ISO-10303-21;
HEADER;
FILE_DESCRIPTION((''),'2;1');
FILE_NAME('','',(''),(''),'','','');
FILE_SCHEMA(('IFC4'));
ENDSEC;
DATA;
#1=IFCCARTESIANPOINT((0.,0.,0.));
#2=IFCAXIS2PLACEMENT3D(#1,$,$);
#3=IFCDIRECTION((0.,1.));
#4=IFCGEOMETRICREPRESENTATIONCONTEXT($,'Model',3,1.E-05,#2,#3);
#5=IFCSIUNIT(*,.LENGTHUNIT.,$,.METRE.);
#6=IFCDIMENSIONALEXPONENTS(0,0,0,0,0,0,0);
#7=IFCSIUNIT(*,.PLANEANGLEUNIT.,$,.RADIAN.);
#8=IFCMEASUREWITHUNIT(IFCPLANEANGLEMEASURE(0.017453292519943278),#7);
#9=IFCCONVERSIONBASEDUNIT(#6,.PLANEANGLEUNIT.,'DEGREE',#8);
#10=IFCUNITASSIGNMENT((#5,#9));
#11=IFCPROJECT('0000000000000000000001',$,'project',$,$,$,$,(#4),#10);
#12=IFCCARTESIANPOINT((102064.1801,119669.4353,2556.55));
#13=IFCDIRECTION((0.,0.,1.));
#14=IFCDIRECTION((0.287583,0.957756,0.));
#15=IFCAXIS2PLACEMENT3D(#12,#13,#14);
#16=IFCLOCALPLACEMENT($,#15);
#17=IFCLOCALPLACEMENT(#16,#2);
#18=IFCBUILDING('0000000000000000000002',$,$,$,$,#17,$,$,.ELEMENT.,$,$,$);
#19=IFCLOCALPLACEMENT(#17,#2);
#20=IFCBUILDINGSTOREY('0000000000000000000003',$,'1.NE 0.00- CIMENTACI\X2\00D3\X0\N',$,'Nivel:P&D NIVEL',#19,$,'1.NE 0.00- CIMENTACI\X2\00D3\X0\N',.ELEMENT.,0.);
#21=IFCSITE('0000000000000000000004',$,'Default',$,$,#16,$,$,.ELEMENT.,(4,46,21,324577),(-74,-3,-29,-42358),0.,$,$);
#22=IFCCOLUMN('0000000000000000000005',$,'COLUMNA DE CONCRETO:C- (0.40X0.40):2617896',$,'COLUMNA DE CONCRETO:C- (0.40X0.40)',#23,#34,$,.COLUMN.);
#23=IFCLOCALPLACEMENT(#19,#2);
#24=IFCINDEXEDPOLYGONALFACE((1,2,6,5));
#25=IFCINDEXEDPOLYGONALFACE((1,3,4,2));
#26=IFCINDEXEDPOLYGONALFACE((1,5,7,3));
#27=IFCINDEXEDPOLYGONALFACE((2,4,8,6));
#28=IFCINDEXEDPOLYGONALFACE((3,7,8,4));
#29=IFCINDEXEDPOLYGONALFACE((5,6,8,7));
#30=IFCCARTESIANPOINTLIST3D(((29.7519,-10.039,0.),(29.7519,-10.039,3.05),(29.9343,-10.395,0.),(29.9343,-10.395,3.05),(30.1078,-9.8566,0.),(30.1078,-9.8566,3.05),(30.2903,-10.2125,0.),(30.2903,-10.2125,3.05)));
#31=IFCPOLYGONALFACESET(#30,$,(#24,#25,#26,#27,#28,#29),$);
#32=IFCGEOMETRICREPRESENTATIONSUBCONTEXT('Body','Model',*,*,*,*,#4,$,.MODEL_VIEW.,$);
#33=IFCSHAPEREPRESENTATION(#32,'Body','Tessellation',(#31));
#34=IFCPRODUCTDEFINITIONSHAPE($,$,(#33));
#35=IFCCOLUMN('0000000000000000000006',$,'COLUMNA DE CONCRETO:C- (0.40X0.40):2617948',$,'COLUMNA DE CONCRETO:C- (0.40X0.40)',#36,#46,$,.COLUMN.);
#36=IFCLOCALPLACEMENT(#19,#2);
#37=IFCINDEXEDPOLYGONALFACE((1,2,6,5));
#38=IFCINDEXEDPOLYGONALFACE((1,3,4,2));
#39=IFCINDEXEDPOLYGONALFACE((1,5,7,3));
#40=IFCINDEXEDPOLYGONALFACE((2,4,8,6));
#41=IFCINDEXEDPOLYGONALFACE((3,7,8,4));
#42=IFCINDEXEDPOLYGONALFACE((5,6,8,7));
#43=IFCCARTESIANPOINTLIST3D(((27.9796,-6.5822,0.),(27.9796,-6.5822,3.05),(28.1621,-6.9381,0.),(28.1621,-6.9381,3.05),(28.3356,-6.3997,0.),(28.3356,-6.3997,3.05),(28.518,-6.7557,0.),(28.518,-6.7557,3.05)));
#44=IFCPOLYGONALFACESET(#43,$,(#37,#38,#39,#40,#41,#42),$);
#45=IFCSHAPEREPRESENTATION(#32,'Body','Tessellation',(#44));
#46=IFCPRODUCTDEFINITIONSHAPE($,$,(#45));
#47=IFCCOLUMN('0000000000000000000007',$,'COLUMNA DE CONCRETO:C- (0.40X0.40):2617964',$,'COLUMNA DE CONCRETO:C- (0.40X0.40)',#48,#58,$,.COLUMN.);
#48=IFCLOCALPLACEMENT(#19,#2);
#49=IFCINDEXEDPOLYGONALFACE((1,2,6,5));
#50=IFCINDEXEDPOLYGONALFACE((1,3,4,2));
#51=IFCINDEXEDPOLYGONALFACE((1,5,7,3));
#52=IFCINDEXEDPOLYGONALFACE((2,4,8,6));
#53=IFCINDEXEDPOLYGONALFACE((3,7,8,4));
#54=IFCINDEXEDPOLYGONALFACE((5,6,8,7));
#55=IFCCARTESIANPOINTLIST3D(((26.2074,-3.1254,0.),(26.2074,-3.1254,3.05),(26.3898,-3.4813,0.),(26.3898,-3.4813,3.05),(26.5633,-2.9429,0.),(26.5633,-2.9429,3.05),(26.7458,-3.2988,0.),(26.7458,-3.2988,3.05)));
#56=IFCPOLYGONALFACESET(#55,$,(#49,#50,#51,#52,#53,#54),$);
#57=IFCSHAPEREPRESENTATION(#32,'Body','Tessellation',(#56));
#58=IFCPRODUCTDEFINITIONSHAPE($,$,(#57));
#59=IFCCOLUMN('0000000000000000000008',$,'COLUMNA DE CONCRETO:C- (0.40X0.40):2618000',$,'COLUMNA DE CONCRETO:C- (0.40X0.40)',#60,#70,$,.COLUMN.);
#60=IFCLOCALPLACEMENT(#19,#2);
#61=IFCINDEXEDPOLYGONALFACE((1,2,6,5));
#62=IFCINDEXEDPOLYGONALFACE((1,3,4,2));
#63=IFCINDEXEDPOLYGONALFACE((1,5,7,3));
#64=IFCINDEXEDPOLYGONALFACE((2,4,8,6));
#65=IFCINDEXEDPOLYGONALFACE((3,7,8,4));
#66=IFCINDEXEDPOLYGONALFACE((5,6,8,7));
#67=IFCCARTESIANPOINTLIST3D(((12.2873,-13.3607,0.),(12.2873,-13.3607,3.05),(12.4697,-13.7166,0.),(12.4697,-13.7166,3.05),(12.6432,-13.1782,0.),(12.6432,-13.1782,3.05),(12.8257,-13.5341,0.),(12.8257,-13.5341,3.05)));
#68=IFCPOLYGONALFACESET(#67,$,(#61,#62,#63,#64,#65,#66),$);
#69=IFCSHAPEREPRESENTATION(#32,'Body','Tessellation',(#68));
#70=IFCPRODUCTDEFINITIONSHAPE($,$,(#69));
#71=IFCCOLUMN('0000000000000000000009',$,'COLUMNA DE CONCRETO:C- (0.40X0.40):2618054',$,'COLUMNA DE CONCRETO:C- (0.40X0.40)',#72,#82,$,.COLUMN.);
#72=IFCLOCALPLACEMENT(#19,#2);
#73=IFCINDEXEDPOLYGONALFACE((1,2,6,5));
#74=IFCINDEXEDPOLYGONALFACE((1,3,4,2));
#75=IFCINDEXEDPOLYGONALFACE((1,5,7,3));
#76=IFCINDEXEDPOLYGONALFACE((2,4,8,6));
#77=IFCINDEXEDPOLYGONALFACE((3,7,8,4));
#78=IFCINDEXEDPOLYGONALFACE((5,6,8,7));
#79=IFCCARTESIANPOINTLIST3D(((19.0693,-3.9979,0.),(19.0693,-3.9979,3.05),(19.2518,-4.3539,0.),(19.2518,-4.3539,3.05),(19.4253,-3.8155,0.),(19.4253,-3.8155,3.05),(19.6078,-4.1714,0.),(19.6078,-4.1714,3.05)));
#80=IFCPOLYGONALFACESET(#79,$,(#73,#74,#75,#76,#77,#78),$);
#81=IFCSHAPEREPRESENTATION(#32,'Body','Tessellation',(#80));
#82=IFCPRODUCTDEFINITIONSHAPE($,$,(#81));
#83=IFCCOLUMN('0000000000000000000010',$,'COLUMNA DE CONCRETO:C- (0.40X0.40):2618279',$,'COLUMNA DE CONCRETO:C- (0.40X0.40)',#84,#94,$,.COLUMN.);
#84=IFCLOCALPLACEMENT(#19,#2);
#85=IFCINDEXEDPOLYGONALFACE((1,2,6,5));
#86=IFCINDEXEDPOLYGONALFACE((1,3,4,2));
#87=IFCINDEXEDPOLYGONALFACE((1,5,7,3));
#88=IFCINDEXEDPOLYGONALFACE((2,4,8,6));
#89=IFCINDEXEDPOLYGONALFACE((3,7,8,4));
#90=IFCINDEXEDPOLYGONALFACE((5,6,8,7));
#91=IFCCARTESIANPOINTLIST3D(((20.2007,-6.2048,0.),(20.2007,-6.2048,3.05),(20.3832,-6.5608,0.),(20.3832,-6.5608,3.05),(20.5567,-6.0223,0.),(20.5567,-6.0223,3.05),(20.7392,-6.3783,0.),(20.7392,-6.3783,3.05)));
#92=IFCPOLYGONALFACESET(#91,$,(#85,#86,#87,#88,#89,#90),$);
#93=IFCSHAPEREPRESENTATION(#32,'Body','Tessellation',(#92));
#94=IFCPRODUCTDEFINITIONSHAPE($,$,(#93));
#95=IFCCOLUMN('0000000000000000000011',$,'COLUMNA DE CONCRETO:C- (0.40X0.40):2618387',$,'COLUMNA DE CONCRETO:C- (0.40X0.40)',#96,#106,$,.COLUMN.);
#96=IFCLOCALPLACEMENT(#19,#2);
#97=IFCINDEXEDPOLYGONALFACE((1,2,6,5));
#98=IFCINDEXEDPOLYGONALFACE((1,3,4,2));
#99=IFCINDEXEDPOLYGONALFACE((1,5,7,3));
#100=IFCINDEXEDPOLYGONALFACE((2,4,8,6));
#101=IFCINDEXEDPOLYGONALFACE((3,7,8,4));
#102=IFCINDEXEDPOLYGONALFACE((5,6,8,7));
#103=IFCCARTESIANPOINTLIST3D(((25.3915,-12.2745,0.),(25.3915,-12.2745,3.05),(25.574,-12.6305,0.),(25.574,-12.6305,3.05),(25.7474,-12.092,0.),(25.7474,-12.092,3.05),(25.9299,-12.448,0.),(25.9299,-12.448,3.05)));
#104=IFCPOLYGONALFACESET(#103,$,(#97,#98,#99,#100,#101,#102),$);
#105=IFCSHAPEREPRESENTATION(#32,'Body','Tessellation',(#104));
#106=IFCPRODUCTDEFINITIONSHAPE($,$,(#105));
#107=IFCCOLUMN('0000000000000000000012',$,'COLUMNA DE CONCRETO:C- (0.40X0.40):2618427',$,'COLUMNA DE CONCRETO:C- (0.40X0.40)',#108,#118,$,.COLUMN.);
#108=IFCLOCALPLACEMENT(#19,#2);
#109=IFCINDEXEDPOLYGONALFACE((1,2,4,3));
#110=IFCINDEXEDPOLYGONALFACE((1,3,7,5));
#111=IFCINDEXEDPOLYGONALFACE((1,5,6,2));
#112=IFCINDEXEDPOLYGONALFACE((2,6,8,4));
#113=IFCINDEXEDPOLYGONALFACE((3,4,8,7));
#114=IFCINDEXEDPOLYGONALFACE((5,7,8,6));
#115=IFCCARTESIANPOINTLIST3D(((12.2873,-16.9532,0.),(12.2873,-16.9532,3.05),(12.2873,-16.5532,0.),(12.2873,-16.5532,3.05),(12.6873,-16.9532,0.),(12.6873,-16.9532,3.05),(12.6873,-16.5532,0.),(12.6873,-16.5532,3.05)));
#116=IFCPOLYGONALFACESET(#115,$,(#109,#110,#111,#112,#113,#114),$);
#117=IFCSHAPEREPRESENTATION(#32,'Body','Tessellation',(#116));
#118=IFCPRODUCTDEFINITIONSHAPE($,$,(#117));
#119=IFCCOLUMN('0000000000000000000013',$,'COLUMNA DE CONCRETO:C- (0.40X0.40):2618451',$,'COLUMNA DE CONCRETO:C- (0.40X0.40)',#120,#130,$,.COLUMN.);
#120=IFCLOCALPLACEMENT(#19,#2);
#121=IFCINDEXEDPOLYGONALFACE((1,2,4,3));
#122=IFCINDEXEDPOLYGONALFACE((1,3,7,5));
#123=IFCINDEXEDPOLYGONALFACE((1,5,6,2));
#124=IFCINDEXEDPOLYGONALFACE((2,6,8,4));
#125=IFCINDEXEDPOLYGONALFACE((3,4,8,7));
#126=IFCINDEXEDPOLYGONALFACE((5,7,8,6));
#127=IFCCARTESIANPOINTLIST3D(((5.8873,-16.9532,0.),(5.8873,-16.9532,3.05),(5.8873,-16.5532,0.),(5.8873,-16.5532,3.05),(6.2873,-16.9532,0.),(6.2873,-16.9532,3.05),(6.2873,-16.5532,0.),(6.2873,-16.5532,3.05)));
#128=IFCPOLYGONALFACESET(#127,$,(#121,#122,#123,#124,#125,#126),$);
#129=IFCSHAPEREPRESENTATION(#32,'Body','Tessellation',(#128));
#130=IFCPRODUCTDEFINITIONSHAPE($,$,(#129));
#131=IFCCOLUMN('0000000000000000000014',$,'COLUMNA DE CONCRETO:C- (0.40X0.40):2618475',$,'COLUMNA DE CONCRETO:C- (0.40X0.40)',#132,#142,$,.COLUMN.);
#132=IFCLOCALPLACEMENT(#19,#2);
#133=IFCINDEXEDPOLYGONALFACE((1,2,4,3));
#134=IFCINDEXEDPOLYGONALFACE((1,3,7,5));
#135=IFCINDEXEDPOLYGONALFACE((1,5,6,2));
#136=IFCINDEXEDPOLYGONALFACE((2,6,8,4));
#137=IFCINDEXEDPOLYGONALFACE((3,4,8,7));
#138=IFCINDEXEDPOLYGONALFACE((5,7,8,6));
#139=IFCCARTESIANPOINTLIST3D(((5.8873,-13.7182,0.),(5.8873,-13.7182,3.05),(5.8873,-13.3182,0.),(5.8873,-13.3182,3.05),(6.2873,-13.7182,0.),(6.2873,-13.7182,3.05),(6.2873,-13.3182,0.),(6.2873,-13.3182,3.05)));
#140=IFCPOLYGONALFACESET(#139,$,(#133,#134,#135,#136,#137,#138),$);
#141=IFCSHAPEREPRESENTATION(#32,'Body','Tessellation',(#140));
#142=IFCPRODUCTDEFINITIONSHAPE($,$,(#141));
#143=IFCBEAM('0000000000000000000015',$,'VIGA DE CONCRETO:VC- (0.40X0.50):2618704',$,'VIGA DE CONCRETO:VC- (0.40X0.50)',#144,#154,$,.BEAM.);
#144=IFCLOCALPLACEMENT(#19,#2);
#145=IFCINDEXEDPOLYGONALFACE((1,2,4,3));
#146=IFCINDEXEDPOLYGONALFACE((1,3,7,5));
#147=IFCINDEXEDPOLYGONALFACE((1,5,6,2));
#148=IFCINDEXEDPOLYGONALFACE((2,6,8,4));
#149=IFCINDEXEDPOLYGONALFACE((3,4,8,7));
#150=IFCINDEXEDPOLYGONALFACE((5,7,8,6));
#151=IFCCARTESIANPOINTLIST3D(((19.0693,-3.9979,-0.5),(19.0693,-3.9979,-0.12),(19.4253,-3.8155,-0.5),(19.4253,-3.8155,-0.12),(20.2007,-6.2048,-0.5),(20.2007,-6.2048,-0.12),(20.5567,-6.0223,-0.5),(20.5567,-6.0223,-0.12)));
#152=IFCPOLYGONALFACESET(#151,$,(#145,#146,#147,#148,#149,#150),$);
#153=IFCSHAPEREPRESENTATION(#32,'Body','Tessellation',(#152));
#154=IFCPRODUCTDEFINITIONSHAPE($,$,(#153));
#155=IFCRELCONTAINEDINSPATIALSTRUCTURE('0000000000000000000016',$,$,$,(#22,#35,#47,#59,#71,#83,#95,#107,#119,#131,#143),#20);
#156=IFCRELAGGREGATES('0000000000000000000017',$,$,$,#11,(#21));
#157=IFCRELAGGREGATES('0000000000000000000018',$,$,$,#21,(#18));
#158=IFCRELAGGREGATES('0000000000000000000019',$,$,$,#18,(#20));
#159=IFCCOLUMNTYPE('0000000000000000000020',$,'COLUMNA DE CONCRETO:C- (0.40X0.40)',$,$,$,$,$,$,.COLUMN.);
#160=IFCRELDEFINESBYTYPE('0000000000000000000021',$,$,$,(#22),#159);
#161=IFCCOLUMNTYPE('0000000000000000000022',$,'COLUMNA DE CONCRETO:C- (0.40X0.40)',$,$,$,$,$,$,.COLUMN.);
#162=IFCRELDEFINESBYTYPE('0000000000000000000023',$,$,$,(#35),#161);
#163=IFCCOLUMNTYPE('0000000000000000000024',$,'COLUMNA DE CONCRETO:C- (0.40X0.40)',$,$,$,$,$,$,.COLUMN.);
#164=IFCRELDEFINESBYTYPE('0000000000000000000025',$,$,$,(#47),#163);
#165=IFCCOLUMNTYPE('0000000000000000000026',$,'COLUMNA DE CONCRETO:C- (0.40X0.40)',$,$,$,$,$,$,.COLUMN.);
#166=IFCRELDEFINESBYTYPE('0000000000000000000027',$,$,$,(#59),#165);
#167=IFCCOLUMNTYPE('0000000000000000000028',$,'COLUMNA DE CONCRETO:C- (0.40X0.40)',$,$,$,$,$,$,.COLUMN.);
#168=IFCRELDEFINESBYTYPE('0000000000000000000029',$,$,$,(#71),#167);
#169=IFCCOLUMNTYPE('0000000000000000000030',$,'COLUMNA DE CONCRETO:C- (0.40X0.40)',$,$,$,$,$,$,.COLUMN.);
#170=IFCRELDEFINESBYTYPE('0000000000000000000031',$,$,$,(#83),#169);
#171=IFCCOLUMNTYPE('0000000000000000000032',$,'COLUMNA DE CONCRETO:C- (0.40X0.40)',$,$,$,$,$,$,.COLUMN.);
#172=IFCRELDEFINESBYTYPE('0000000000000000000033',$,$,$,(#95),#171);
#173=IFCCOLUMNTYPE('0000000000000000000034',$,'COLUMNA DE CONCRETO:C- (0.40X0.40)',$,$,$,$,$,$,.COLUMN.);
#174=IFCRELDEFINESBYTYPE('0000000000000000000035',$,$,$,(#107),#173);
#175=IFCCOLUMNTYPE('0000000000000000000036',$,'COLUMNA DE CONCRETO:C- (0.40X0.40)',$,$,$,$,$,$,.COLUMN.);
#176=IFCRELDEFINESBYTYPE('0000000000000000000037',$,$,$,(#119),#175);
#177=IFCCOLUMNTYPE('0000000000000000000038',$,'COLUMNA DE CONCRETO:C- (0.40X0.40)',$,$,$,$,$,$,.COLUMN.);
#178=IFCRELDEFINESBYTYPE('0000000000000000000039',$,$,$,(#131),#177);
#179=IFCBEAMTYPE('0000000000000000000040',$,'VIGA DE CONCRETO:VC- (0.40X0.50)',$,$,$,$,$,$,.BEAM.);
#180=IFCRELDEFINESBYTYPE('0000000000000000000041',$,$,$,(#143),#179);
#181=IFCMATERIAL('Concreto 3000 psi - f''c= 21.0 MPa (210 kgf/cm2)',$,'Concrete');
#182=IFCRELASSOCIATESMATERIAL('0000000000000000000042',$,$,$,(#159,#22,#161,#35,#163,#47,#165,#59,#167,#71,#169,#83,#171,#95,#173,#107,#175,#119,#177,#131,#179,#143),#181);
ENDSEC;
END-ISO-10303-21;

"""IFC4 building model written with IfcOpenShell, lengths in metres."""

from ifc_helpers import new_model, entity, si_unit, converted_unit, direction, frame, origin, place, context, subcontext, project, spatial, indexed_curve, outline, extrude, source, transform, mapped, material, type_object, type_shapes, element, save


model = new_model("IFC4")

# Units and contexts
model_context = context("Model", 3, precision=1e-05, world=origin(), true_north=direction((0.0, 1.0)))
body_context = subcontext(model_context, "Body", "Model", "MODEL_VIEW")
ifc_project = project(units=[si_unit("LENGTHUNIT", "METRE"), converted_unit("PLANEANGLEUNIT", "DEGREE", entity("IfcPlaneAngleMeasure", 0.017453292519943278), si_unit("PLANEANGLEUNIT", "RADIAN"), dimensions=[0, 0, 0, 0, 0, 0, 0])], contexts=[model_context])

# Site, building, storey
site_placement = place(None, frame((102064.1801, 119669.4353, 2556.55), z_axis=(0.0, 0.0, 1.0), x_axis=(0.287583, 0.957756, 0.0)))
site = spatial("IfcSite", under=ifc_project, at=site_placement, Name="Default", CompositionType="ELEMENT", RefLatitude=(4, 46, 21, 324577), RefLongitude=(-74, -3, -29, -42358), RefElevation=0.0)
building_placement = place(site_placement, origin())
building = spatial("IfcBuilding", under=site, at=building_placement, CompositionType="ELEMENT")
storey_placement = place(building_placement, origin())
storey = spatial("IfcBuildingStorey", under=building, at=storey_placement, Name="1.NE 0.00- CIMENTACIÓN", ObjectType="Nivel:P&D NIVEL", LongName="1.NE 0.00- CIMENTACIÓN", CompositionType="ELEMENT", Elevation=0.0)

# Columns
ifc_material = material(Name="Concreto 3000 psi - f'c= 21.0 MPa (210 kgf/cm2)", Category="Concrete")
column_type_1 = type_object("IfcColumnType", Name="COLUMNA DE CONCRETO:C- (0.40X0.40)", PredefinedType="COLUMN", material=ifc_material)
shared_shape_1 = source(origin(), body_context, "Body", "SweptSolid", [
    extrude(outline(indexed_curve([(-0.2, -0.2), (0.2, -0.2), (0.2, 0.2), (-0.2, 0.2), (-0.2, -0.2)], self_intersect=False)), frame((30.0211, -10.1258, 0.0), z_axis=(0.0, 0.0, 1.0), x_axis=(-0.889869, -0.456217, 0.0)), (0.0, 0.0, 1.0), 3.05),
])
type_shapes(column_type_1, [shared_shape_1])
column_1_placement = place(storey_placement, origin())
element("IfcColumn", 1, at=column_1_placement, inside=storey, type_object=column_type_1, material=ifc_material, Name="COLUMNA DE CONCRETO:C- (0.40X0.40):2617896", ObjectType="COLUMNA DE CONCRETO:C- (0.40X0.40)", PredefinedType="COLUMN", context=body_context, shape_type="MappedRepresentation", body=[
    mapped(shared_shape_1, transform((0.0, 0.0, 0.0), scale=1.0)),
])
column_type_2 = type_object("IfcColumnType", Name="COLUMNA DE CONCRETO:C- (0.40X0.40)", PredefinedType="COLUMN", material=ifc_material)
shared_shape_2 = source(origin(), body_context, "Body", "SweptSolid", [
    extrude(outline(indexed_curve([(-0.2, -0.2), (0.2, -0.2), (0.2, 0.2), (-0.2, 0.2), (-0.2, -0.2)], self_intersect=False)), frame((28.2488, -6.6689, 0.0), z_axis=(0.0, 0.0, 1.0), x_axis=(-0.889869, -0.456217, 0.0)), (0.0, 0.0, 1.0), 3.05),
])
type_shapes(column_type_2, [shared_shape_2])
column_2_placement = place(storey_placement, origin())
element("IfcColumn", 2, at=column_2_placement, inside=storey, type_object=column_type_2, material=ifc_material, Name="COLUMNA DE CONCRETO:C- (0.40X0.40):2617948", ObjectType="COLUMNA DE CONCRETO:C- (0.40X0.40)", PredefinedType="COLUMN", context=body_context, shape_type="MappedRepresentation", body=[
    mapped(shared_shape_2, transform((0.0, 0.0, 0.0), scale=1.0)),
])
column_type_3 = type_object("IfcColumnType", Name="COLUMNA DE CONCRETO:C- (0.40X0.40)", PredefinedType="COLUMN", material=ifc_material)
shared_shape_3 = source(origin(), body_context, "Body", "SweptSolid", [
    extrude(outline(indexed_curve([(-0.2, -0.2), (0.2, -0.2), (0.2, 0.2), (-0.2, 0.2), (-0.2, -0.2)], self_intersect=False)), frame((26.4766, -3.2121, 0.0), z_axis=(0.0, 0.0, 1.0), x_axis=(-0.889869, -0.456217, 0.0)), (0.0, 0.0, 1.0), 3.05),
])
type_shapes(column_type_3, [shared_shape_3])
column_3_placement = place(storey_placement, origin())
element("IfcColumn", 3, at=column_3_placement, inside=storey, type_object=column_type_3, material=ifc_material, Name="COLUMNA DE CONCRETO:C- (0.40X0.40):2617964", ObjectType="COLUMNA DE CONCRETO:C- (0.40X0.40)", PredefinedType="COLUMN", context=body_context, shape_type="MappedRepresentation", body=[
    mapped(shared_shape_3, transform((0.0, 0.0, 0.0), scale=1.0)),
])
column_type_4 = type_object("IfcColumnType", Name="COLUMNA DE CONCRETO:C- (0.40X0.40)", PredefinedType="COLUMN", material=ifc_material)
shared_shape_4 = source(origin(), body_context, "Body", "SweptSolid", [
    extrude(outline(indexed_curve([(-0.2, -0.2), (0.2, -0.2), (0.2, 0.2), (-0.2, 0.2), (-0.2, -0.2)], self_intersect=False)), frame((12.5565, -13.4474, 0.0), z_axis=(0.0, 0.0, 1.0), x_axis=(-0.889869, -0.456217, 0.0)), (0.0, 0.0, 1.0), 3.05),
])
type_shapes(column_type_4, [shared_shape_4])
column_4_placement = place(storey_placement, origin())
element("IfcColumn", 4, at=column_4_placement, inside=storey, type_object=column_type_4, material=ifc_material, Name="COLUMNA DE CONCRETO:C- (0.40X0.40):2618000", ObjectType="COLUMNA DE CONCRETO:C- (0.40X0.40)", PredefinedType="COLUMN", context=body_context, shape_type="MappedRepresentation", body=[
    mapped(shared_shape_4, transform((0.0, 0.0, 0.0), scale=1.0)),
])
column_type_5 = type_object("IfcColumnType", Name="COLUMNA DE CONCRETO:C- (0.40X0.40)", PredefinedType="COLUMN", material=ifc_material)
shared_shape_5 = source(origin(), body_context, "Body", "SweptSolid", [
    extrude(outline(indexed_curve([(-0.2, -0.2), (0.2, -0.2), (0.2, 0.2), (-0.2, 0.2), (-0.2, -0.2)], self_intersect=False)), frame((19.3385, -4.0847, 0.0), z_axis=(0.0, 0.0, 1.0), x_axis=(-0.889869, -0.456217, 0.0)), (0.0, 0.0, 1.0), 3.05),
])
type_shapes(column_type_5, [shared_shape_5])
column_5_placement = place(storey_placement, origin())
element("IfcColumn", 5, at=column_5_placement, inside=storey, type_object=column_type_5, material=ifc_material, Name="COLUMNA DE CONCRETO:C- (0.40X0.40):2618054", ObjectType="COLUMNA DE CONCRETO:C- (0.40X0.40)", PredefinedType="COLUMN", context=body_context, shape_type="MappedRepresentation", body=[
    mapped(shared_shape_5, transform((0.0, 0.0, 0.0), scale=1.0)),
])
column_type_6 = type_object("IfcColumnType", Name="COLUMNA DE CONCRETO:C- (0.40X0.40)", PredefinedType="COLUMN", material=ifc_material)
shared_shape_6 = source(origin(), body_context, "Body", "SweptSolid", [
    extrude(outline(indexed_curve([(-0.2, -0.2), (0.2, -0.2), (0.2, 0.2), (-0.2, 0.2), (-0.2, -0.2)], self_intersect=False)), frame((20.47, -6.2915, 0.0), z_axis=(0.0, 0.0, 1.0), x_axis=(-0.889869, -0.456217, 0.0)), (0.0, 0.0, 1.0), 3.05),
])
type_shapes(column_type_6, [shared_shape_6])
column_6_placement = place(storey_placement, origin())
element("IfcColumn", 6, at=column_6_placement, inside=storey, type_object=column_type_6, material=ifc_material, Name="COLUMNA DE CONCRETO:C- (0.40X0.40):2618279", ObjectType="COLUMNA DE CONCRETO:C- (0.40X0.40)", PredefinedType="COLUMN", context=body_context, shape_type="MappedRepresentation", body=[
    mapped(shared_shape_6, transform((0.0, 0.0, 0.0), scale=1.0)),
])
column_type_7 = type_object("IfcColumnType", Name="COLUMNA DE CONCRETO:C- (0.40X0.40)", PredefinedType="COLUMN", material=ifc_material)
shared_shape_7 = source(origin(), body_context, "Body", "SweptSolid", [
    extrude(outline(indexed_curve([(-0.2, -0.2), (0.2, -0.2), (0.2, 0.2), (-0.2, 0.2), (-0.2, -0.2)], self_intersect=False)), frame((25.6607, -12.3612, 0.0), z_axis=(0.0, 0.0, 1.0), x_axis=(-0.889869, -0.456217, 0.0)), (0.0, 0.0, 1.0), 3.05),
])
type_shapes(column_type_7, [shared_shape_7])
column_7_placement = place(storey_placement, origin())
element("IfcColumn", 7, at=column_7_placement, inside=storey, type_object=column_type_7, material=ifc_material, Name="COLUMNA DE CONCRETO:C- (0.40X0.40):2618387", ObjectType="COLUMNA DE CONCRETO:C- (0.40X0.40)", PredefinedType="COLUMN", context=body_context, shape_type="MappedRepresentation", body=[
    mapped(shared_shape_7, transform((0.0, 0.0, 0.0), scale=1.0)),
])
column_type_8 = type_object("IfcColumnType", Name="COLUMNA DE CONCRETO:C- (0.40X0.40)", PredefinedType="COLUMN", material=ifc_material)
shared_shape_8 = source(origin(), body_context, "Body", "SweptSolid", [
    extrude(outline(indexed_curve([(-0.2, -0.2), (0.2, -0.2), (0.2, 0.2), (-0.2, 0.2), (-0.2, -0.2)], self_intersect=False)), frame((12.4873, -16.7532, 0.0), z_axis=(0.0, 0.0, 1.0), x_axis=(-1.0, 0.0, 0.0)), (0.0, 0.0, 1.0), 3.05),
])
type_shapes(column_type_8, [shared_shape_8])
column_8_placement = place(storey_placement, origin())
element("IfcColumn", 8, at=column_8_placement, inside=storey, type_object=column_type_8, material=ifc_material, Name="COLUMNA DE CONCRETO:C- (0.40X0.40):2618427", ObjectType="COLUMNA DE CONCRETO:C- (0.40X0.40)", PredefinedType="COLUMN", context=body_context, shape_type="MappedRepresentation", body=[
    mapped(shared_shape_8, transform((0.0, 0.0, 0.0), scale=1.0)),
])
column_type_9 = type_object("IfcColumnType", Name="COLUMNA DE CONCRETO:C- (0.40X0.40)", PredefinedType="COLUMN", material=ifc_material)
shared_shape_9 = source(origin(), body_context, "Body", "SweptSolid", [
    extrude(outline(indexed_curve([(-0.2, -0.2), (0.2, -0.2), (0.2, 0.2), (-0.2, 0.2), (-0.2, -0.2)], self_intersect=False)), frame((6.0873, -16.7532, 0.0), z_axis=(0.0, 0.0, 1.0), x_axis=(-1.0, 0.0, 0.0)), (0.0, 0.0, 1.0), 3.05),
])
type_shapes(column_type_9, [shared_shape_9])
column_9_placement = place(storey_placement, origin())
element("IfcColumn", 9, at=column_9_placement, inside=storey, type_object=column_type_9, material=ifc_material, Name="COLUMNA DE CONCRETO:C- (0.40X0.40):2618451", ObjectType="COLUMNA DE CONCRETO:C- (0.40X0.40)", PredefinedType="COLUMN", context=body_context, shape_type="MappedRepresentation", body=[
    mapped(shared_shape_9, transform((0.0, 0.0, 0.0), scale=1.0)),
])
column_type_10 = type_object("IfcColumnType", Name="COLUMNA DE CONCRETO:C- (0.40X0.40)", PredefinedType="COLUMN", material=ifc_material)
shared_shape_10 = source(origin(), body_context, "Body", "SweptSolid", [
    extrude(outline(indexed_curve([(-0.2, -0.2), (0.2, -0.2), (0.2, 0.2), (-0.2, 0.2), (-0.2, -0.2)], self_intersect=False)), frame((6.0873, -13.5182, 0.0), z_axis=(0.0, 0.0, 1.0), x_axis=(-1.0, 0.0, 0.0)), (0.0, 0.0, 1.0), 3.05),
])
type_shapes(column_type_10, [shared_shape_10])
column_10_placement = place(storey_placement, origin())
element("IfcColumn", 10, at=column_10_placement, inside=storey, type_object=column_type_10, material=ifc_material, Name="COLUMNA DE CONCRETO:C- (0.40X0.40):2618475", ObjectType="COLUMNA DE CONCRETO:C- (0.40X0.40)", PredefinedType="COLUMN", context=body_context, shape_type="MappedRepresentation", body=[
    mapped(shared_shape_10, transform((0.0, 0.0, 0.0), scale=1.0)),
])

# Beam
beam_type_1 = type_object("IfcBeamType", Name="VIGA DE CONCRETO:VC- (0.40X0.50)", PredefinedType="BEAM", material=ifc_material)
shared_shape_11 = source(origin(), body_context, "Body", "SweptSolid", [
    extrude(outline(indexed_curve([(-0.19, -0.2), (0.19, -0.2), (0.19, 0.2), (-0.19, 0.2), (-0.19, -0.2)], self_intersect=False)), frame((20.3787, -6.1136, -0.31), z_axis=(-0.456217, 0.889869, 0.0), x_axis=(0.0, 0.0, 1.0)), (0.0, 0.0, 1.0), 2.48),
])
type_shapes(beam_type_1, [shared_shape_11])
beam_1_placement = place(storey_placement, origin())
element("IfcBeam", 11, at=beam_1_placement, inside=storey, type_object=beam_type_1, material=ifc_material, Name="VIGA DE CONCRETO:VC- (0.40X0.50):2618704", ObjectType="VIGA DE CONCRETO:VC- (0.40X0.50)", PredefinedType="BEAM", context=body_context, shape_type="MappedRepresentation", body=[
    mapped(shared_shape_11, transform((0.0, 0.0, 0.0), scale=1.0)),
])

save(model, "model.ifc")
